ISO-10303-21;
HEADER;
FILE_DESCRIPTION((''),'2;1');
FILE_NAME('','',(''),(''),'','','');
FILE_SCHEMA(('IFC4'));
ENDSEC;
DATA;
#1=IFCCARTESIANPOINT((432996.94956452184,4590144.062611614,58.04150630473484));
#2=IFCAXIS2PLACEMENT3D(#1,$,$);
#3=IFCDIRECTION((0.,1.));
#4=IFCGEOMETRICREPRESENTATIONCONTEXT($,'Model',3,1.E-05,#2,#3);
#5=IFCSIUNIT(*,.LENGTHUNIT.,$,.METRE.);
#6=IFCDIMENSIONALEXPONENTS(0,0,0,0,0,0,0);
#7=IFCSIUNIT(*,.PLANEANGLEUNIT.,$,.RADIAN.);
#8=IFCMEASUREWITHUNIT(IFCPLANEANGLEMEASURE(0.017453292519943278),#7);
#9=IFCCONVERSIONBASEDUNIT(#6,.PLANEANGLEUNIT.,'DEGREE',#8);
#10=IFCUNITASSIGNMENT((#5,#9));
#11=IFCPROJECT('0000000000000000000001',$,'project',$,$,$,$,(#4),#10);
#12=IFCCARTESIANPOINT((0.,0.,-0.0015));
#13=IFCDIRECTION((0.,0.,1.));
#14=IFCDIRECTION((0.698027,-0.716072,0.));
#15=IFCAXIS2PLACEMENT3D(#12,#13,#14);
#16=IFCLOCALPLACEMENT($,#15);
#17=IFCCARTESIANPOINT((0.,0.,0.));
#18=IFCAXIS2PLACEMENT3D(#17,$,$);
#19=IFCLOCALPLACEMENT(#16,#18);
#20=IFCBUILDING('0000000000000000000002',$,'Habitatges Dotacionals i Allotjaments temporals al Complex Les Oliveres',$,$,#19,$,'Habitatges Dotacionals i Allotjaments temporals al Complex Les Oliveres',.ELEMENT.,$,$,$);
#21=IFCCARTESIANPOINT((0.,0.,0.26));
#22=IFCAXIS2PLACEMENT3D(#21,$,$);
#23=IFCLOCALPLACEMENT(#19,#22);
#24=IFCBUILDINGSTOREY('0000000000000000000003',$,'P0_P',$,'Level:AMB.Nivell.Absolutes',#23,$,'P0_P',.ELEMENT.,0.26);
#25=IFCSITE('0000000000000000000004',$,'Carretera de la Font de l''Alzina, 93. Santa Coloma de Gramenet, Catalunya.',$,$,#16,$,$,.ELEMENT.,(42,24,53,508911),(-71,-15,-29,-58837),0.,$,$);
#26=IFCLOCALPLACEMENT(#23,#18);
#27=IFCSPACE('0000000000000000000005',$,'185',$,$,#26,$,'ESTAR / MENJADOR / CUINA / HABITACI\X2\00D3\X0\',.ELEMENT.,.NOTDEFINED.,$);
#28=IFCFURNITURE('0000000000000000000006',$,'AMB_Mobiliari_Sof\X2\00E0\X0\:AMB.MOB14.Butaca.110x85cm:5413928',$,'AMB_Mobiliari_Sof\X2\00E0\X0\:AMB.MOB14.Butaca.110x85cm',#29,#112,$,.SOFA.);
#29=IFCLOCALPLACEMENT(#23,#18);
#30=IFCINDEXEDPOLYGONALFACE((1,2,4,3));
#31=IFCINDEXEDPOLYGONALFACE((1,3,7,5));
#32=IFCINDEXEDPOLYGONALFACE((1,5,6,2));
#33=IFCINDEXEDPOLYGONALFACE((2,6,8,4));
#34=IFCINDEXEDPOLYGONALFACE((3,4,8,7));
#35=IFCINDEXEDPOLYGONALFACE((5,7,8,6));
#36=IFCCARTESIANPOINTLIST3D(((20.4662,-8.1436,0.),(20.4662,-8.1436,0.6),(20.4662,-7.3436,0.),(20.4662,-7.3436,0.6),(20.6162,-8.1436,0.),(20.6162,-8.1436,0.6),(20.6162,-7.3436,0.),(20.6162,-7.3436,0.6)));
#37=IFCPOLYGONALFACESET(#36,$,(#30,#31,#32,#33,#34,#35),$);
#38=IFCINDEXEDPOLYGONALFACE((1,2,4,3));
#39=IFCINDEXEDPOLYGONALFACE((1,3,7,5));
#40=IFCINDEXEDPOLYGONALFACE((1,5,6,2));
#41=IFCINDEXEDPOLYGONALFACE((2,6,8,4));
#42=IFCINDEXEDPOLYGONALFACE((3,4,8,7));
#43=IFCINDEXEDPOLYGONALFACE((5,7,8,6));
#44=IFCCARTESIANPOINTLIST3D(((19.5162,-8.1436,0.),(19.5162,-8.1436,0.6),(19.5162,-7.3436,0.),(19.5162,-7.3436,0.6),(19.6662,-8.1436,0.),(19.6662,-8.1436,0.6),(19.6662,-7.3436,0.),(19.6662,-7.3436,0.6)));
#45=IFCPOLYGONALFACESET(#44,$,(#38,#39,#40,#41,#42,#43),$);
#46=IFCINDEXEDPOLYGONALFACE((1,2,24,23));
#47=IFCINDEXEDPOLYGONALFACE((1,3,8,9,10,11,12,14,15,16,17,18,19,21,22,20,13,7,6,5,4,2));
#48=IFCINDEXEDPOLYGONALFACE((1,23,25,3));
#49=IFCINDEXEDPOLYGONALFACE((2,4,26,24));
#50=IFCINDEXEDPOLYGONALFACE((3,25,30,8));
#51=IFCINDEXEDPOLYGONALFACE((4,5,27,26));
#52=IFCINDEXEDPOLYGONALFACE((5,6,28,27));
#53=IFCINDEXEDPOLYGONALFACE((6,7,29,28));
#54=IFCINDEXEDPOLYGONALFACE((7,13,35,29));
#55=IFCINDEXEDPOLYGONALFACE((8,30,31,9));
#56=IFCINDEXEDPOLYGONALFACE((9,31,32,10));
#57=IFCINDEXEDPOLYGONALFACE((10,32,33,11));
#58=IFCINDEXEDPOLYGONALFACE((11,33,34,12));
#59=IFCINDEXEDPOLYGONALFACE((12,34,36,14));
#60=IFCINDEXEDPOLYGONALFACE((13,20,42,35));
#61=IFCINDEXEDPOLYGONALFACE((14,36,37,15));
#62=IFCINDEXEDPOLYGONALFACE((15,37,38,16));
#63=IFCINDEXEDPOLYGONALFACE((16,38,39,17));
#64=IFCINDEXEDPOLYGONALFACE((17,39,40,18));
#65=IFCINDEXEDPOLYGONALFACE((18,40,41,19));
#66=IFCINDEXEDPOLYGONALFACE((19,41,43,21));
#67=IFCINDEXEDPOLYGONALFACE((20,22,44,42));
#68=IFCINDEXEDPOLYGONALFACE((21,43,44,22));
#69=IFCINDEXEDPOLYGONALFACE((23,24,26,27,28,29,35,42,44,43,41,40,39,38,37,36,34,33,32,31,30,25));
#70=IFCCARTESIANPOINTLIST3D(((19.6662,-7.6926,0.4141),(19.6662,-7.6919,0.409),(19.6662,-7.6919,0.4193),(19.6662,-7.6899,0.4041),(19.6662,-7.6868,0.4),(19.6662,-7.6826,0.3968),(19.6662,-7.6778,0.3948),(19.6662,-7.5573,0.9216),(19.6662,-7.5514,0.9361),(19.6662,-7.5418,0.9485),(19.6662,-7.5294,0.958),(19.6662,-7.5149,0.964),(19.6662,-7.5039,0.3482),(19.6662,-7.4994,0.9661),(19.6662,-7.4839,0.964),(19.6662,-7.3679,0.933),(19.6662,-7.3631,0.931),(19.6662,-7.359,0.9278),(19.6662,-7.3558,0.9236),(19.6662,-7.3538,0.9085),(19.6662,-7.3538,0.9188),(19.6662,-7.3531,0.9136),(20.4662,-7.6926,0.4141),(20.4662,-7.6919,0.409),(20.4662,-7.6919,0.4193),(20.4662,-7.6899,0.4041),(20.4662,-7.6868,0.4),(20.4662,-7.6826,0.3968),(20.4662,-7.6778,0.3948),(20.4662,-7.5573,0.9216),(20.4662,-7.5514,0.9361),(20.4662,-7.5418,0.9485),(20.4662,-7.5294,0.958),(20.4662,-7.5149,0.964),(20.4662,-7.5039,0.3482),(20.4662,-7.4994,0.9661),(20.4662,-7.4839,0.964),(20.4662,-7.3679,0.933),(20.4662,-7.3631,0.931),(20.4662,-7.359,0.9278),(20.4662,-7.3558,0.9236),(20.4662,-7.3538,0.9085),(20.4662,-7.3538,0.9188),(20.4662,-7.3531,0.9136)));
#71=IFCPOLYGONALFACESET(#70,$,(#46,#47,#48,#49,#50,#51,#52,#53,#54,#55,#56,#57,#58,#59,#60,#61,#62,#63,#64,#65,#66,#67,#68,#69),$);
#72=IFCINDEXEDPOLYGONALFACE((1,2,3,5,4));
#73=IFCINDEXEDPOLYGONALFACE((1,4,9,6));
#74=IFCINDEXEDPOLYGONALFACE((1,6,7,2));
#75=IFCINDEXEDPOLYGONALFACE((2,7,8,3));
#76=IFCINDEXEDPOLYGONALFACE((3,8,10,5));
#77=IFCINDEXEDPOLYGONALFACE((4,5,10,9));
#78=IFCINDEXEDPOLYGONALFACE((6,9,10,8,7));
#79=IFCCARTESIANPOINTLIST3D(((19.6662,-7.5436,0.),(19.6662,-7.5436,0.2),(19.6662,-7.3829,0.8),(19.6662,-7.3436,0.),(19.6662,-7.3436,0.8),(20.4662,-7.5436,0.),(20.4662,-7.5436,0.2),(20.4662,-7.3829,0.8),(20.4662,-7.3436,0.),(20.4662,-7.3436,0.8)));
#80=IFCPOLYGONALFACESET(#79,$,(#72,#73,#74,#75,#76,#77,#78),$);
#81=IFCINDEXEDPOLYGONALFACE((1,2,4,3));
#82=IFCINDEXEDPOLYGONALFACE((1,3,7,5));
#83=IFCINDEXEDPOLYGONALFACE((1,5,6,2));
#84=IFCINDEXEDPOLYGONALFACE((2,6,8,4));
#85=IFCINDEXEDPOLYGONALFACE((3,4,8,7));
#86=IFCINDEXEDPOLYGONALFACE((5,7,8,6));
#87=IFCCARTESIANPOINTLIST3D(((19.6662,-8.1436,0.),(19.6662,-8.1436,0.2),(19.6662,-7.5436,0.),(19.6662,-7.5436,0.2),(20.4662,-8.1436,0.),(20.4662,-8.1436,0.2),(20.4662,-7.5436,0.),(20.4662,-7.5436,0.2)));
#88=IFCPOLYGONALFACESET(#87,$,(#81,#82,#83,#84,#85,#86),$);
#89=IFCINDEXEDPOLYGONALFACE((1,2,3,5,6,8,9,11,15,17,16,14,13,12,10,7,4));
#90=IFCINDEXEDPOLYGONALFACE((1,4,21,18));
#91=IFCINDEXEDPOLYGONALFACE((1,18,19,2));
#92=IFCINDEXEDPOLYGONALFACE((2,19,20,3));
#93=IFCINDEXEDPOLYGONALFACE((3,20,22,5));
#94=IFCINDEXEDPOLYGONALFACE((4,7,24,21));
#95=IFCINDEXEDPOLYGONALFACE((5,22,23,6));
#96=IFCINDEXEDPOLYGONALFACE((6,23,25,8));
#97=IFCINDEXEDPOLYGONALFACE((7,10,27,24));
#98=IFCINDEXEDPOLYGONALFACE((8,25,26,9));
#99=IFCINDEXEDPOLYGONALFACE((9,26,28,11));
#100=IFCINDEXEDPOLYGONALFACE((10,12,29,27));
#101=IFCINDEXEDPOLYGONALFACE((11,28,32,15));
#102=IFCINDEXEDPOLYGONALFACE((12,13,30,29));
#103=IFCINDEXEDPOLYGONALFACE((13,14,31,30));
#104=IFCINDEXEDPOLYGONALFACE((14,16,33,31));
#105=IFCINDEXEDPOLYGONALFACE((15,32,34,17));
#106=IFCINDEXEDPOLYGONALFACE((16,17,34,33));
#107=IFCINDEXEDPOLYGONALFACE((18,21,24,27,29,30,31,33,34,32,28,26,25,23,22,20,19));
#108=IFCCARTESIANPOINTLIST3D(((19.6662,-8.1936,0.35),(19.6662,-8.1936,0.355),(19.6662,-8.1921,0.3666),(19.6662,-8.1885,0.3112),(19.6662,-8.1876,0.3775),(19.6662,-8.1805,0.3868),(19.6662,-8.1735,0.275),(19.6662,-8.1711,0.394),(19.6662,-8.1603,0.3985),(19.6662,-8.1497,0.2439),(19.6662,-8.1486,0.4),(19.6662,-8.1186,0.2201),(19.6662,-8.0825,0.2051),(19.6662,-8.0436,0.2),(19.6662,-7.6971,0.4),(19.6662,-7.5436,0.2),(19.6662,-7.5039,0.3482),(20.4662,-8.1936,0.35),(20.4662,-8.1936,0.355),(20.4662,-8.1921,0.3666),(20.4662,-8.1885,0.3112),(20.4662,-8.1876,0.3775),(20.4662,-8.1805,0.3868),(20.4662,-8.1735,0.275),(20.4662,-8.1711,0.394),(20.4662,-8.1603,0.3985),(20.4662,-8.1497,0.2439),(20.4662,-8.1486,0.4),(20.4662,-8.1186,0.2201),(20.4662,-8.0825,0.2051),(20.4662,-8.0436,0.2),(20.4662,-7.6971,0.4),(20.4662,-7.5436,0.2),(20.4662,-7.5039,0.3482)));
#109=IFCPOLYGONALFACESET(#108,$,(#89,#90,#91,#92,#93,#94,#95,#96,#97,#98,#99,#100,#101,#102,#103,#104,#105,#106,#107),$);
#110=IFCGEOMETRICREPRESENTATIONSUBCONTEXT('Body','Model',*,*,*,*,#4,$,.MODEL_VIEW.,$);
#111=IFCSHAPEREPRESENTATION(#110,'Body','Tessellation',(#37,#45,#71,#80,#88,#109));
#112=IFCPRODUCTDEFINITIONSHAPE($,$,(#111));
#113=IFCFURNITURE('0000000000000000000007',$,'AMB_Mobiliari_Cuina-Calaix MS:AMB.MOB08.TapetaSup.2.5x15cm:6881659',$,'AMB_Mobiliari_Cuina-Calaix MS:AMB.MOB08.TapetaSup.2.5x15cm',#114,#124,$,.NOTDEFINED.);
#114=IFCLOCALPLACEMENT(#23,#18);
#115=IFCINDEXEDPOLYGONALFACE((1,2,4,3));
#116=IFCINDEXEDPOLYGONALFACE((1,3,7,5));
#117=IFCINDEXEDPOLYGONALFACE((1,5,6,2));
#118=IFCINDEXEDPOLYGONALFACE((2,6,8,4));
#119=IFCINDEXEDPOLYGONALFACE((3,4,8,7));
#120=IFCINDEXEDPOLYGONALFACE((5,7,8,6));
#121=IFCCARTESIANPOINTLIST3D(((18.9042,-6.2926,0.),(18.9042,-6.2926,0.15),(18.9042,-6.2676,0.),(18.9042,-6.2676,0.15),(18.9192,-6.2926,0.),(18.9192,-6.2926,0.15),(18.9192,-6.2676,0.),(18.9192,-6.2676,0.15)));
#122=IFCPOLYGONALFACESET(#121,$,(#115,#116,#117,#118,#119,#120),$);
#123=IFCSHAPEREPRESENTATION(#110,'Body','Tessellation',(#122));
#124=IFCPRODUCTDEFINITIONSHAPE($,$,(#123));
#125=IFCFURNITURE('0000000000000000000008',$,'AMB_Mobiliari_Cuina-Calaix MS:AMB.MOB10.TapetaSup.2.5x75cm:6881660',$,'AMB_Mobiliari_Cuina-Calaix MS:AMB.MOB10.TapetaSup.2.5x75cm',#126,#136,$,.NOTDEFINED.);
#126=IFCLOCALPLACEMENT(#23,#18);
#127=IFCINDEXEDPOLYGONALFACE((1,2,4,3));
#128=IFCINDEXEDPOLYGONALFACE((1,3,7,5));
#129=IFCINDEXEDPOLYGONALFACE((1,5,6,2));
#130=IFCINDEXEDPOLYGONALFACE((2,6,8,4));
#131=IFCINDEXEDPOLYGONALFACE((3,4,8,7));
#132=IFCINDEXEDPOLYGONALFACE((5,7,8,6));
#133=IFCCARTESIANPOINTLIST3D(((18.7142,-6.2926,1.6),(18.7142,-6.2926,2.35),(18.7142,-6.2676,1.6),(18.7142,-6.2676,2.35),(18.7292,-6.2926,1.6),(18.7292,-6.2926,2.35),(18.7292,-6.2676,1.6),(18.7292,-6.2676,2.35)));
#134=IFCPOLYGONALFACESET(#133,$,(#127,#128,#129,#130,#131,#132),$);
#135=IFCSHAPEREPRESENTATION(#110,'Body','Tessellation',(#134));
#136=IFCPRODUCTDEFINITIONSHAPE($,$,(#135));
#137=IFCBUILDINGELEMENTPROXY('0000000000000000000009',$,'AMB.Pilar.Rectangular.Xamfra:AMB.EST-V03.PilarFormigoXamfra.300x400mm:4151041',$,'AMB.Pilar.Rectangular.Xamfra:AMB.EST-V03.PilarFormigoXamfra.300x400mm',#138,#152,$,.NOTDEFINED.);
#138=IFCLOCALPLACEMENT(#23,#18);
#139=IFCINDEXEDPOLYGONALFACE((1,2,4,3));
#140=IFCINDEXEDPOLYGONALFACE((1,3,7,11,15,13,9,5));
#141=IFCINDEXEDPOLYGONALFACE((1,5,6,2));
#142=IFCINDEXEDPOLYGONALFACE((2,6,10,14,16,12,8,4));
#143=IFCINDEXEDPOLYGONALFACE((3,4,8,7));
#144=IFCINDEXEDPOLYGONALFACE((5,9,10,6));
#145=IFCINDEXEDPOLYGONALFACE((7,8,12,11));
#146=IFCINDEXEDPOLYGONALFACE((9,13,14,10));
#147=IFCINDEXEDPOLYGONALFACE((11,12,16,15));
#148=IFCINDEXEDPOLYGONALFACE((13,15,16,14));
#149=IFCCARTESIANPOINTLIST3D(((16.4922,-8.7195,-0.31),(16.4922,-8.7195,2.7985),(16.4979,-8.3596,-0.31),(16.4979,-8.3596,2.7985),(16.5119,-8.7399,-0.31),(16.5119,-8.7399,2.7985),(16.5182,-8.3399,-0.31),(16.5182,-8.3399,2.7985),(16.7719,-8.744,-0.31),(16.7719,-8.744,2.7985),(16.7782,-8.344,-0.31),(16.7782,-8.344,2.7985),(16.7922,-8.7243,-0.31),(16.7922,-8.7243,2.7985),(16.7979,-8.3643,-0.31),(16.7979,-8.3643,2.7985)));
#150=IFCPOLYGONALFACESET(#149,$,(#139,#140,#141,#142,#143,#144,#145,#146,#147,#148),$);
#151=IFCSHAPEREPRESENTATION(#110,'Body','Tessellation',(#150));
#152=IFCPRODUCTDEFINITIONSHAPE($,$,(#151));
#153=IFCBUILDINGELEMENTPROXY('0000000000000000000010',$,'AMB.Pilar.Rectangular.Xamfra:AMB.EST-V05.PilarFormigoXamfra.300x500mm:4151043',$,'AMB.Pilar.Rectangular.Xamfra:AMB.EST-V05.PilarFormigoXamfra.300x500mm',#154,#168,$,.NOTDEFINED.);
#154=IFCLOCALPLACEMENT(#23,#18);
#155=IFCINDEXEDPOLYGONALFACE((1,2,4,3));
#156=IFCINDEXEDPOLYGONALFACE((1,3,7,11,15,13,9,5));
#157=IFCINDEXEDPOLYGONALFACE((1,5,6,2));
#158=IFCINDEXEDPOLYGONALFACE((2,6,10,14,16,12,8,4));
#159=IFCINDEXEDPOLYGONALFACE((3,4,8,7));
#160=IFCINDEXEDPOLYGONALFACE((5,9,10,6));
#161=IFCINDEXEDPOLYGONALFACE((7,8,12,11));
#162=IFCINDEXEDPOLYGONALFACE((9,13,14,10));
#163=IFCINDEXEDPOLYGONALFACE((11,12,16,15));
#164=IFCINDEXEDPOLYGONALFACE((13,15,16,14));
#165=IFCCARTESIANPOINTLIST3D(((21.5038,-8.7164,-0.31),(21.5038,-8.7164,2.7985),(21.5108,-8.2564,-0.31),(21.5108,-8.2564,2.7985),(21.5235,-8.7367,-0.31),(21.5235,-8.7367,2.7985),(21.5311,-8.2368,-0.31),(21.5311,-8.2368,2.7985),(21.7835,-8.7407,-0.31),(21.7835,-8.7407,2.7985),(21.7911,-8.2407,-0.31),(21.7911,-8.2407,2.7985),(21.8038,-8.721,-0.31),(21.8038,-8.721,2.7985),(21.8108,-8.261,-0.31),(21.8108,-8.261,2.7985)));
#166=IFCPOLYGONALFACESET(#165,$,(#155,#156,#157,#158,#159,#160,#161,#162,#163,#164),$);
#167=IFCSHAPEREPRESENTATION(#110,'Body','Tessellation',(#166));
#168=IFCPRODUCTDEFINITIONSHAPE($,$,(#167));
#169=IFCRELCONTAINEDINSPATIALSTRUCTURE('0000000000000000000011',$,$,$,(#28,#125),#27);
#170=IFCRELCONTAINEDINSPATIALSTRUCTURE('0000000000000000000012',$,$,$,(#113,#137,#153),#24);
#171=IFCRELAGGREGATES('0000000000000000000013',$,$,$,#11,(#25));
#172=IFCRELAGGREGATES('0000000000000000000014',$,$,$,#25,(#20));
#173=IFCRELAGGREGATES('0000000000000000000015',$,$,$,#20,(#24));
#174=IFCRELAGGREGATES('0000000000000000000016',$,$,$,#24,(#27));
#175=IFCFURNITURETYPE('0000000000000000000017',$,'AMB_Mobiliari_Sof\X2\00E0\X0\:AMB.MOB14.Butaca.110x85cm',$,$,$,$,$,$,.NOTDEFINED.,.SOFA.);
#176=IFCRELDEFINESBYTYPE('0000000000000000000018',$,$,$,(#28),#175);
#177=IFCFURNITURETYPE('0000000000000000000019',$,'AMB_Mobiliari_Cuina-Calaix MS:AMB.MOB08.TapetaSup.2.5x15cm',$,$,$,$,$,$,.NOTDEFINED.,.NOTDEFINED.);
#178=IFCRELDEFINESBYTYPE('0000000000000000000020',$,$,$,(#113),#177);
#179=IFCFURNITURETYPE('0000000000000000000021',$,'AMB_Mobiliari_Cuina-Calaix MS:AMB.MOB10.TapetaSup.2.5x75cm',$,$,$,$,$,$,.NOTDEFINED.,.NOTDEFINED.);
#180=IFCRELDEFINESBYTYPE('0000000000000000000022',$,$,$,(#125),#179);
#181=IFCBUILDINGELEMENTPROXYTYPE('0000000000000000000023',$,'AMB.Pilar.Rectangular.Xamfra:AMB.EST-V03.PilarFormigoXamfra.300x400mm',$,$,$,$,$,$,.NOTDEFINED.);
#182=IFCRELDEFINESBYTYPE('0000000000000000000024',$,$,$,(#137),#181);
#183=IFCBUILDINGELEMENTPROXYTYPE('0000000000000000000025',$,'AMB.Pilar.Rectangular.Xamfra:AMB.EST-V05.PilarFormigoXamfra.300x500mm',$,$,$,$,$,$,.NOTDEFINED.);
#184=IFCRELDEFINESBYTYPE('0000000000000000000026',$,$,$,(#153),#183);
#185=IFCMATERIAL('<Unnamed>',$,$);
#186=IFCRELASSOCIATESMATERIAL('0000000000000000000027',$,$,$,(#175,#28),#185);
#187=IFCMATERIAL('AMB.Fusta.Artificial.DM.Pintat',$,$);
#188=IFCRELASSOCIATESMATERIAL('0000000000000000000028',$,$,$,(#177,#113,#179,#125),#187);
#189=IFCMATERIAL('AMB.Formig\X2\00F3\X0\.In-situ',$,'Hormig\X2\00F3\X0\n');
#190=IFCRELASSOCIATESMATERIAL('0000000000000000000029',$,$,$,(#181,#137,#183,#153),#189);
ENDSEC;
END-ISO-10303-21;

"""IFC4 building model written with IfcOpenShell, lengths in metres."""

from ifc_helpers import new_model, entity, si_unit, converted_unit, direction, frame, origin, place, context, subcontext, project, spatial, line, arc, indexed_curve, outline, extrude, source, transform, mapped, material, type_object, type_shapes, element, save


model = new_model("IFC4")

# Units and contexts
model_context = context("Model", 3, precision=1e-05, world=frame((432996.94956452184, 4590144.062611614, 58.04150630473484)), true_north=direction((0.0, 1.0)))
body_context = subcontext(model_context, "Body", "Model", "MODEL_VIEW")
ifc_project = project(units=[si_unit("LENGTHUNIT", "METRE"), converted_unit("PLANEANGLEUNIT", "DEGREE", entity("IfcPlaneAngleMeasure", 0.017453292519943278), si_unit("PLANEANGLEUNIT", "RADIAN"), dimensions=[0, 0, 0, 0, 0, 0, 0])], contexts=[model_context])

# Site, building, storey
site_placement = place(None, frame((0.0, 0.0, -0.0015), z_axis=(0.0, 0.0, 1.0), x_axis=(0.698027, -0.716072, 0.0)))
site = spatial("IfcSite", under=ifc_project, at=site_placement, Name="Carretera de la Font de l'Alzina, 93. Santa Coloma de Gramenet, Catalunya.", CompositionType="ELEMENT", RefLatitude=(42, 24, 53, 508911), RefLongitude=(-71, -15, -29, -58837), RefElevation=0.0)
building_placement = place(site_placement, origin())
building = spatial("IfcBuilding", under=site, at=building_placement, Name="Habitatges Dotacionals i Allotjaments temporals al Complex Les Oliveres", LongName="Habitatges Dotacionals i Allotjaments temporals al Complex Les Oliveres", CompositionType="ELEMENT")
storey_placement = place(building_placement, frame((0.0, 0.0, 0.26)))
storey = spatial("IfcBuildingStorey", under=building, at=storey_placement, Name="P0_P", ObjectType="Level:AMB.Nivell.Absolutes", LongName="P0_P", CompositionType="ELEMENT", Elevation=0.26)

# Shared definitions
ifc_material_1 = material(Name="AMB.Formigó.In-situ", Category="Hormigón")

# Shared definitions
ifc_material_2 = material(Name="AMB.Fusta.Artificial.DM.Pintat")

# Shared definitions
space_1_placement = place(storey_placement, origin())
space_1 = spatial("IfcSpace", under=storey, at=space_1_placement, Name="185", LongName="ESTAR / MENJADOR / CUINA / HABITACIÓ", CompositionType="ELEMENT", PredefinedType="NOTDEFINED")

# Furniture
ifc_material_3 = material(Name="<Unnamed>")
furniture_type_1 = type_object("IfcFurnitureType", Name="AMB_Mobiliari_Sofà:AMB.MOB14.Butaca.110x85cm", AssemblyPlace="NOTDEFINED", PredefinedType="SOFA", material=ifc_material_3)
shared_shape_1 = source(origin(), body_context, "Body", "SweptSolid", [
    extrude(outline(indexed_curve([(-0.4, -0.075), (0.4, -0.075), (0.4, 0.075), (-0.4, 0.075), (-0.4, -0.075)], self_intersect=False)), frame((0.075, -0.4, 0.05), z_axis=(0.0, 0.0, 1.0), x_axis=(0.0, 1.0, 0.0)), (0.0, 0.0, 1.0), 0.6),
    extrude(outline(indexed_curve([(-0.075, -0.4), (0.075, -0.4), (0.075, 0.4), (-0.075, 0.4), (-0.075, -0.4)], self_intersect=False)), frame((-0.875, -0.4, 0.05)), (0.0, 0.0, 1.0), 0.6),
    extrude(outline(indexed_curve([(-0.3143, 0.0943), (-0.3284, 0.0884), (-0.3343, 0.0743), (-0.3343, -0.1057), (0.2457, -0.1057), (0.2599, -0.0999), (0.2657, -0.0857), (0.2657, 0.0343), (0.2481, 0.0767), (0.2057, 0.0943)], segments=[arc(1, 2, 3), line(3, 4, 5), arc(5, 6, 7), line(7, 8), arc(8, 9, 10), line(10, 1)], self_intersect=False)), frame((-0.8, -0.1759, 0.7485), z_axis=(1.0, 0.0, 0.0), x_axis=(0.0, 0.258819, 0.965926)), (0.0, 0.0, 1.0), 0.8),
    extrude(outline(indexed_curve([(-0.0878, -0.44), (-0.0486, -0.44), (0.1122, 0.16), (0.1122, 0.36), (-0.0878, 0.36), (-0.0878, -0.44)], self_intersect=False)), frame((-0.8, -0.0878, 0.41), z_axis=(1.0, 0.0, 0.0), x_axis=(0.0, -1.0, 0.0)), (0.0, 0.0, 1.0), 0.8),
    extrude(outline(indexed_curve([(-0.3, -0.4), (0.3, -0.4), (0.3, 0.4), (-0.3, 0.4), (-0.3, -0.4)], self_intersect=False)), frame((-0.4, -0.5, 0.05), z_axis=(0.0, 0.0, 1.0), x_axis=(0.0, 1.0, 0.0)), (0.0, 0.0, 1.0), 0.2),
    extrude(outline(indexed_curve([(-0.2064, -0.0781), (0.2452, -0.0781), (0.277, -0.0649), (0.2902, -0.0331), (0.2902, -0.0281), (0.2462, 0.078), (0.1402, 0.1219), (-0.3598, 0.1219), (-0.3995, -0.0263)], segments=[line(1, 2), arc(2, 3, 4), line(4, 5), arc(5, 6, 7), line(7, 8, 9, 1)], self_intersect=False)), frame((-0.8, -0.5598, 0.3719), z_axis=(1.0, 0.0, 0.0), x_axis=(0.0, -1.0, 0.0)), (0.0, 0.0, 1.0), 0.8),
])
type_shapes(furniture_type_1, [shared_shape_1])
furniture_1_placement = place(space_1_placement, frame((20.4662, -7.3436, -0.05)))
element("IfcFurniture", 1, at=furniture_1_placement, inside=space_1, type_object=furniture_type_1, material=ifc_material_3, Name="AMB_Mobiliari_Sofà:AMB.MOB14.Butaca.110x85cm:5413928", ObjectType="AMB_Mobiliari_Sofà:AMB.MOB14.Butaca.110x85cm", PredefinedType="SOFA", context=body_context, shape_type="MappedRepresentation", body=[
    mapped(shared_shape_1, transform((0.0, 0.0, 0.0), scale=1.0)),
])
furniture_type_2 = type_object("IfcFurnitureType", Name="AMB_Mobiliari_Cuina-Calaix MS:AMB.MOB08.TapetaSup.2.5x15cm", AssemblyPlace="NOTDEFINED", PredefinedType="NOTDEFINED", material=ifc_material_2)
shared_shape_2 = source(origin(), body_context, "Body", "SweptSolid", [
    extrude(outline(indexed_curve([(-0.0075, -0.0125), (0.0075, -0.0125), (0.0075, 0.0125), (-0.0075, 0.0125), (-0.0075, -0.0125)], self_intersect=False)), frame((-0.797, 0.0075, 0.0), z_axis=(0.0, 0.0, 1.0), x_axis=(0.0, 1.0, 0.0)), (0.0, 0.0, 1.0), 0.15),
])
type_shapes(furniture_type_2, [shared_shape_2])
furniture_2_placement = place(storey_placement, frame((18.9192, -5.4831, 0.0), z_axis=(0.0, 0.0, 1.0), x_axis=(0.0, 1.0, 0.0)))
element("IfcFurniture", 2, at=furniture_2_placement, inside=storey, type_object=furniture_type_2, material=ifc_material_2, Name="AMB_Mobiliari_Cuina-Calaix MS:AMB.MOB08.TapetaSup.2.5x15cm:6881659", ObjectType="AMB_Mobiliari_Cuina-Calaix MS:AMB.MOB08.TapetaSup.2.5x15cm", PredefinedType="NOTDEFINED", context=body_context, shape_type="MappedRepresentation", body=[
    mapped(shared_shape_2, transform((0.0, 0.0, 0.0), scale=1.0)),
])
furniture_type_3 = type_object("IfcFurnitureType", Name="AMB_Mobiliari_Cuina-Calaix MS:AMB.MOB10.TapetaSup.2.5x75cm", AssemblyPlace="NOTDEFINED", PredefinedType="NOTDEFINED", material=ifc_material_2)
shared_shape_3 = source(origin(), body_context, "Body", "SweptSolid", [
    extrude(outline(indexed_curve([(-0.0075, -0.0125), (0.0075, -0.0125), (0.0075, 0.0125), (-0.0075, 0.0125), (-0.0075, -0.0125)], self_intersect=False)), frame((-0.797, 0.0075, 0.0), z_axis=(0.0, 0.0, 1.0), x_axis=(0.0, 1.0, 0.0)), (0.0, 0.0, 1.0), 0.75),
])
type_shapes(furniture_type_3, [shared_shape_3])
furniture_3_placement = place(space_1_placement, frame((18.7292, -5.4831, 1.6), z_axis=(0.0, 0.0, 1.0), x_axis=(0.0, 1.0, 0.0)))
element("IfcFurniture", 3, at=furniture_3_placement, inside=space_1, type_object=furniture_type_3, material=ifc_material_2, Name="AMB_Mobiliari_Cuina-Calaix MS:AMB.MOB10.TapetaSup.2.5x75cm:6881660", ObjectType="AMB_Mobiliari_Cuina-Calaix MS:AMB.MOB10.TapetaSup.2.5x75cm", PredefinedType="NOTDEFINED", context=body_context, shape_type="MappedRepresentation", body=[
    mapped(shared_shape_3, transform((0.0, 0.0, 0.0), scale=1.0)),
])

# Building element proxies
building_element_proxy_type_1 = type_object("IfcBuildingElementProxyType", Name="AMB.Pilar.Rectangular.Xamfra:AMB.EST-V03.PilarFormigoXamfra.300x400mm", PredefinedType="NOTDEFINED", material=ifc_material_1)
shared_shape_4 = source(origin(), body_context, "Body", "SweptSolid", [
    extrude(outline(indexed_curve([(-0.13, -0.2), (0.13, -0.2), (0.15, -0.18), (0.15, 0.18), (0.13, 0.2), (-0.13, 0.2), (-0.15, 0.18), (-0.15, -0.18), (-0.13, -0.2)], self_intersect=False)), frame((0.0, 0.0, -0.05), z_axis=(0.0, 0.0, 1.0), x_axis=(-1.0, 0.0, 0.0)), (0.0, 0.0, 1.0), 3.1085),
])
type_shapes(building_element_proxy_type_1, [shared_shape_4])
proxy_1_placement = place(storey_placement, frame((16.6451, -8.5419, -0.26), z_axis=(0.0, 0.0, 1.0), x_axis=(0.999875, -0.015782, 0.0)))
element("IfcBuildingElementProxy", 4, at=proxy_1_placement, inside=storey, type_object=building_element_proxy_type_1, material=ifc_material_1, Name="AMB.Pilar.Rectangular.Xamfra:AMB.EST-V03.PilarFormigoXamfra.300x400mm:4151041", ObjectType="AMB.Pilar.Rectangular.Xamfra:AMB.EST-V03.PilarFormigoXamfra.300x400mm", PredefinedType="NOTDEFINED", context=body_context, shape_type="MappedRepresentation", body=[
    mapped(shared_shape_4, transform((0.0, 0.0, 0.0), scale=1.0)),
])
building_element_proxy_type_2 = type_object("IfcBuildingElementProxyType", Name="AMB.Pilar.Rectangular.Xamfra:AMB.EST-V05.PilarFormigoXamfra.300x500mm", PredefinedType="NOTDEFINED", material=ifc_material_1)
shared_shape_5 = source(origin(), body_context, "Body", "SweptSolid", [
    extrude(outline(indexed_curve([(-0.13, -0.25), (0.13, -0.25), (0.15, -0.23), (0.15, 0.23), (0.13, 0.25), (-0.13, 0.25), (-0.15, 0.23), (-0.15, -0.23), (-0.13, -0.25)], self_intersect=False)), frame((0.0, 0.0, -0.05), z_axis=(0.0, 0.0, 1.0), x_axis=(-1.0, 0.0, 0.0)), (0.0, 0.0, 1.0), 3.1085),
])
type_shapes(building_element_proxy_type_2, [shared_shape_5])
proxy_2_placement = place(storey_placement, frame((21.6573, -8.4887, -0.26), z_axis=(0.0, 0.0, 1.0), x_axis=(0.999884, -0.015231, 0.0)))
element("IfcBuildingElementProxy", 5, at=proxy_2_placement, inside=storey, type_object=building_element_proxy_type_2, material=ifc_material_1, Name="AMB.Pilar.Rectangular.Xamfra:AMB.EST-V05.PilarFormigoXamfra.300x500mm:4151043", ObjectType="AMB.Pilar.Rectangular.Xamfra:AMB.EST-V05.PilarFormigoXamfra.300x500mm", PredefinedType="NOTDEFINED", context=body_context, shape_type="MappedRepresentation", body=[
    mapped(shared_shape_5, transform((0.0, 0.0, 0.0), scale=1.0)),
])

save(model, "model.ifc")
